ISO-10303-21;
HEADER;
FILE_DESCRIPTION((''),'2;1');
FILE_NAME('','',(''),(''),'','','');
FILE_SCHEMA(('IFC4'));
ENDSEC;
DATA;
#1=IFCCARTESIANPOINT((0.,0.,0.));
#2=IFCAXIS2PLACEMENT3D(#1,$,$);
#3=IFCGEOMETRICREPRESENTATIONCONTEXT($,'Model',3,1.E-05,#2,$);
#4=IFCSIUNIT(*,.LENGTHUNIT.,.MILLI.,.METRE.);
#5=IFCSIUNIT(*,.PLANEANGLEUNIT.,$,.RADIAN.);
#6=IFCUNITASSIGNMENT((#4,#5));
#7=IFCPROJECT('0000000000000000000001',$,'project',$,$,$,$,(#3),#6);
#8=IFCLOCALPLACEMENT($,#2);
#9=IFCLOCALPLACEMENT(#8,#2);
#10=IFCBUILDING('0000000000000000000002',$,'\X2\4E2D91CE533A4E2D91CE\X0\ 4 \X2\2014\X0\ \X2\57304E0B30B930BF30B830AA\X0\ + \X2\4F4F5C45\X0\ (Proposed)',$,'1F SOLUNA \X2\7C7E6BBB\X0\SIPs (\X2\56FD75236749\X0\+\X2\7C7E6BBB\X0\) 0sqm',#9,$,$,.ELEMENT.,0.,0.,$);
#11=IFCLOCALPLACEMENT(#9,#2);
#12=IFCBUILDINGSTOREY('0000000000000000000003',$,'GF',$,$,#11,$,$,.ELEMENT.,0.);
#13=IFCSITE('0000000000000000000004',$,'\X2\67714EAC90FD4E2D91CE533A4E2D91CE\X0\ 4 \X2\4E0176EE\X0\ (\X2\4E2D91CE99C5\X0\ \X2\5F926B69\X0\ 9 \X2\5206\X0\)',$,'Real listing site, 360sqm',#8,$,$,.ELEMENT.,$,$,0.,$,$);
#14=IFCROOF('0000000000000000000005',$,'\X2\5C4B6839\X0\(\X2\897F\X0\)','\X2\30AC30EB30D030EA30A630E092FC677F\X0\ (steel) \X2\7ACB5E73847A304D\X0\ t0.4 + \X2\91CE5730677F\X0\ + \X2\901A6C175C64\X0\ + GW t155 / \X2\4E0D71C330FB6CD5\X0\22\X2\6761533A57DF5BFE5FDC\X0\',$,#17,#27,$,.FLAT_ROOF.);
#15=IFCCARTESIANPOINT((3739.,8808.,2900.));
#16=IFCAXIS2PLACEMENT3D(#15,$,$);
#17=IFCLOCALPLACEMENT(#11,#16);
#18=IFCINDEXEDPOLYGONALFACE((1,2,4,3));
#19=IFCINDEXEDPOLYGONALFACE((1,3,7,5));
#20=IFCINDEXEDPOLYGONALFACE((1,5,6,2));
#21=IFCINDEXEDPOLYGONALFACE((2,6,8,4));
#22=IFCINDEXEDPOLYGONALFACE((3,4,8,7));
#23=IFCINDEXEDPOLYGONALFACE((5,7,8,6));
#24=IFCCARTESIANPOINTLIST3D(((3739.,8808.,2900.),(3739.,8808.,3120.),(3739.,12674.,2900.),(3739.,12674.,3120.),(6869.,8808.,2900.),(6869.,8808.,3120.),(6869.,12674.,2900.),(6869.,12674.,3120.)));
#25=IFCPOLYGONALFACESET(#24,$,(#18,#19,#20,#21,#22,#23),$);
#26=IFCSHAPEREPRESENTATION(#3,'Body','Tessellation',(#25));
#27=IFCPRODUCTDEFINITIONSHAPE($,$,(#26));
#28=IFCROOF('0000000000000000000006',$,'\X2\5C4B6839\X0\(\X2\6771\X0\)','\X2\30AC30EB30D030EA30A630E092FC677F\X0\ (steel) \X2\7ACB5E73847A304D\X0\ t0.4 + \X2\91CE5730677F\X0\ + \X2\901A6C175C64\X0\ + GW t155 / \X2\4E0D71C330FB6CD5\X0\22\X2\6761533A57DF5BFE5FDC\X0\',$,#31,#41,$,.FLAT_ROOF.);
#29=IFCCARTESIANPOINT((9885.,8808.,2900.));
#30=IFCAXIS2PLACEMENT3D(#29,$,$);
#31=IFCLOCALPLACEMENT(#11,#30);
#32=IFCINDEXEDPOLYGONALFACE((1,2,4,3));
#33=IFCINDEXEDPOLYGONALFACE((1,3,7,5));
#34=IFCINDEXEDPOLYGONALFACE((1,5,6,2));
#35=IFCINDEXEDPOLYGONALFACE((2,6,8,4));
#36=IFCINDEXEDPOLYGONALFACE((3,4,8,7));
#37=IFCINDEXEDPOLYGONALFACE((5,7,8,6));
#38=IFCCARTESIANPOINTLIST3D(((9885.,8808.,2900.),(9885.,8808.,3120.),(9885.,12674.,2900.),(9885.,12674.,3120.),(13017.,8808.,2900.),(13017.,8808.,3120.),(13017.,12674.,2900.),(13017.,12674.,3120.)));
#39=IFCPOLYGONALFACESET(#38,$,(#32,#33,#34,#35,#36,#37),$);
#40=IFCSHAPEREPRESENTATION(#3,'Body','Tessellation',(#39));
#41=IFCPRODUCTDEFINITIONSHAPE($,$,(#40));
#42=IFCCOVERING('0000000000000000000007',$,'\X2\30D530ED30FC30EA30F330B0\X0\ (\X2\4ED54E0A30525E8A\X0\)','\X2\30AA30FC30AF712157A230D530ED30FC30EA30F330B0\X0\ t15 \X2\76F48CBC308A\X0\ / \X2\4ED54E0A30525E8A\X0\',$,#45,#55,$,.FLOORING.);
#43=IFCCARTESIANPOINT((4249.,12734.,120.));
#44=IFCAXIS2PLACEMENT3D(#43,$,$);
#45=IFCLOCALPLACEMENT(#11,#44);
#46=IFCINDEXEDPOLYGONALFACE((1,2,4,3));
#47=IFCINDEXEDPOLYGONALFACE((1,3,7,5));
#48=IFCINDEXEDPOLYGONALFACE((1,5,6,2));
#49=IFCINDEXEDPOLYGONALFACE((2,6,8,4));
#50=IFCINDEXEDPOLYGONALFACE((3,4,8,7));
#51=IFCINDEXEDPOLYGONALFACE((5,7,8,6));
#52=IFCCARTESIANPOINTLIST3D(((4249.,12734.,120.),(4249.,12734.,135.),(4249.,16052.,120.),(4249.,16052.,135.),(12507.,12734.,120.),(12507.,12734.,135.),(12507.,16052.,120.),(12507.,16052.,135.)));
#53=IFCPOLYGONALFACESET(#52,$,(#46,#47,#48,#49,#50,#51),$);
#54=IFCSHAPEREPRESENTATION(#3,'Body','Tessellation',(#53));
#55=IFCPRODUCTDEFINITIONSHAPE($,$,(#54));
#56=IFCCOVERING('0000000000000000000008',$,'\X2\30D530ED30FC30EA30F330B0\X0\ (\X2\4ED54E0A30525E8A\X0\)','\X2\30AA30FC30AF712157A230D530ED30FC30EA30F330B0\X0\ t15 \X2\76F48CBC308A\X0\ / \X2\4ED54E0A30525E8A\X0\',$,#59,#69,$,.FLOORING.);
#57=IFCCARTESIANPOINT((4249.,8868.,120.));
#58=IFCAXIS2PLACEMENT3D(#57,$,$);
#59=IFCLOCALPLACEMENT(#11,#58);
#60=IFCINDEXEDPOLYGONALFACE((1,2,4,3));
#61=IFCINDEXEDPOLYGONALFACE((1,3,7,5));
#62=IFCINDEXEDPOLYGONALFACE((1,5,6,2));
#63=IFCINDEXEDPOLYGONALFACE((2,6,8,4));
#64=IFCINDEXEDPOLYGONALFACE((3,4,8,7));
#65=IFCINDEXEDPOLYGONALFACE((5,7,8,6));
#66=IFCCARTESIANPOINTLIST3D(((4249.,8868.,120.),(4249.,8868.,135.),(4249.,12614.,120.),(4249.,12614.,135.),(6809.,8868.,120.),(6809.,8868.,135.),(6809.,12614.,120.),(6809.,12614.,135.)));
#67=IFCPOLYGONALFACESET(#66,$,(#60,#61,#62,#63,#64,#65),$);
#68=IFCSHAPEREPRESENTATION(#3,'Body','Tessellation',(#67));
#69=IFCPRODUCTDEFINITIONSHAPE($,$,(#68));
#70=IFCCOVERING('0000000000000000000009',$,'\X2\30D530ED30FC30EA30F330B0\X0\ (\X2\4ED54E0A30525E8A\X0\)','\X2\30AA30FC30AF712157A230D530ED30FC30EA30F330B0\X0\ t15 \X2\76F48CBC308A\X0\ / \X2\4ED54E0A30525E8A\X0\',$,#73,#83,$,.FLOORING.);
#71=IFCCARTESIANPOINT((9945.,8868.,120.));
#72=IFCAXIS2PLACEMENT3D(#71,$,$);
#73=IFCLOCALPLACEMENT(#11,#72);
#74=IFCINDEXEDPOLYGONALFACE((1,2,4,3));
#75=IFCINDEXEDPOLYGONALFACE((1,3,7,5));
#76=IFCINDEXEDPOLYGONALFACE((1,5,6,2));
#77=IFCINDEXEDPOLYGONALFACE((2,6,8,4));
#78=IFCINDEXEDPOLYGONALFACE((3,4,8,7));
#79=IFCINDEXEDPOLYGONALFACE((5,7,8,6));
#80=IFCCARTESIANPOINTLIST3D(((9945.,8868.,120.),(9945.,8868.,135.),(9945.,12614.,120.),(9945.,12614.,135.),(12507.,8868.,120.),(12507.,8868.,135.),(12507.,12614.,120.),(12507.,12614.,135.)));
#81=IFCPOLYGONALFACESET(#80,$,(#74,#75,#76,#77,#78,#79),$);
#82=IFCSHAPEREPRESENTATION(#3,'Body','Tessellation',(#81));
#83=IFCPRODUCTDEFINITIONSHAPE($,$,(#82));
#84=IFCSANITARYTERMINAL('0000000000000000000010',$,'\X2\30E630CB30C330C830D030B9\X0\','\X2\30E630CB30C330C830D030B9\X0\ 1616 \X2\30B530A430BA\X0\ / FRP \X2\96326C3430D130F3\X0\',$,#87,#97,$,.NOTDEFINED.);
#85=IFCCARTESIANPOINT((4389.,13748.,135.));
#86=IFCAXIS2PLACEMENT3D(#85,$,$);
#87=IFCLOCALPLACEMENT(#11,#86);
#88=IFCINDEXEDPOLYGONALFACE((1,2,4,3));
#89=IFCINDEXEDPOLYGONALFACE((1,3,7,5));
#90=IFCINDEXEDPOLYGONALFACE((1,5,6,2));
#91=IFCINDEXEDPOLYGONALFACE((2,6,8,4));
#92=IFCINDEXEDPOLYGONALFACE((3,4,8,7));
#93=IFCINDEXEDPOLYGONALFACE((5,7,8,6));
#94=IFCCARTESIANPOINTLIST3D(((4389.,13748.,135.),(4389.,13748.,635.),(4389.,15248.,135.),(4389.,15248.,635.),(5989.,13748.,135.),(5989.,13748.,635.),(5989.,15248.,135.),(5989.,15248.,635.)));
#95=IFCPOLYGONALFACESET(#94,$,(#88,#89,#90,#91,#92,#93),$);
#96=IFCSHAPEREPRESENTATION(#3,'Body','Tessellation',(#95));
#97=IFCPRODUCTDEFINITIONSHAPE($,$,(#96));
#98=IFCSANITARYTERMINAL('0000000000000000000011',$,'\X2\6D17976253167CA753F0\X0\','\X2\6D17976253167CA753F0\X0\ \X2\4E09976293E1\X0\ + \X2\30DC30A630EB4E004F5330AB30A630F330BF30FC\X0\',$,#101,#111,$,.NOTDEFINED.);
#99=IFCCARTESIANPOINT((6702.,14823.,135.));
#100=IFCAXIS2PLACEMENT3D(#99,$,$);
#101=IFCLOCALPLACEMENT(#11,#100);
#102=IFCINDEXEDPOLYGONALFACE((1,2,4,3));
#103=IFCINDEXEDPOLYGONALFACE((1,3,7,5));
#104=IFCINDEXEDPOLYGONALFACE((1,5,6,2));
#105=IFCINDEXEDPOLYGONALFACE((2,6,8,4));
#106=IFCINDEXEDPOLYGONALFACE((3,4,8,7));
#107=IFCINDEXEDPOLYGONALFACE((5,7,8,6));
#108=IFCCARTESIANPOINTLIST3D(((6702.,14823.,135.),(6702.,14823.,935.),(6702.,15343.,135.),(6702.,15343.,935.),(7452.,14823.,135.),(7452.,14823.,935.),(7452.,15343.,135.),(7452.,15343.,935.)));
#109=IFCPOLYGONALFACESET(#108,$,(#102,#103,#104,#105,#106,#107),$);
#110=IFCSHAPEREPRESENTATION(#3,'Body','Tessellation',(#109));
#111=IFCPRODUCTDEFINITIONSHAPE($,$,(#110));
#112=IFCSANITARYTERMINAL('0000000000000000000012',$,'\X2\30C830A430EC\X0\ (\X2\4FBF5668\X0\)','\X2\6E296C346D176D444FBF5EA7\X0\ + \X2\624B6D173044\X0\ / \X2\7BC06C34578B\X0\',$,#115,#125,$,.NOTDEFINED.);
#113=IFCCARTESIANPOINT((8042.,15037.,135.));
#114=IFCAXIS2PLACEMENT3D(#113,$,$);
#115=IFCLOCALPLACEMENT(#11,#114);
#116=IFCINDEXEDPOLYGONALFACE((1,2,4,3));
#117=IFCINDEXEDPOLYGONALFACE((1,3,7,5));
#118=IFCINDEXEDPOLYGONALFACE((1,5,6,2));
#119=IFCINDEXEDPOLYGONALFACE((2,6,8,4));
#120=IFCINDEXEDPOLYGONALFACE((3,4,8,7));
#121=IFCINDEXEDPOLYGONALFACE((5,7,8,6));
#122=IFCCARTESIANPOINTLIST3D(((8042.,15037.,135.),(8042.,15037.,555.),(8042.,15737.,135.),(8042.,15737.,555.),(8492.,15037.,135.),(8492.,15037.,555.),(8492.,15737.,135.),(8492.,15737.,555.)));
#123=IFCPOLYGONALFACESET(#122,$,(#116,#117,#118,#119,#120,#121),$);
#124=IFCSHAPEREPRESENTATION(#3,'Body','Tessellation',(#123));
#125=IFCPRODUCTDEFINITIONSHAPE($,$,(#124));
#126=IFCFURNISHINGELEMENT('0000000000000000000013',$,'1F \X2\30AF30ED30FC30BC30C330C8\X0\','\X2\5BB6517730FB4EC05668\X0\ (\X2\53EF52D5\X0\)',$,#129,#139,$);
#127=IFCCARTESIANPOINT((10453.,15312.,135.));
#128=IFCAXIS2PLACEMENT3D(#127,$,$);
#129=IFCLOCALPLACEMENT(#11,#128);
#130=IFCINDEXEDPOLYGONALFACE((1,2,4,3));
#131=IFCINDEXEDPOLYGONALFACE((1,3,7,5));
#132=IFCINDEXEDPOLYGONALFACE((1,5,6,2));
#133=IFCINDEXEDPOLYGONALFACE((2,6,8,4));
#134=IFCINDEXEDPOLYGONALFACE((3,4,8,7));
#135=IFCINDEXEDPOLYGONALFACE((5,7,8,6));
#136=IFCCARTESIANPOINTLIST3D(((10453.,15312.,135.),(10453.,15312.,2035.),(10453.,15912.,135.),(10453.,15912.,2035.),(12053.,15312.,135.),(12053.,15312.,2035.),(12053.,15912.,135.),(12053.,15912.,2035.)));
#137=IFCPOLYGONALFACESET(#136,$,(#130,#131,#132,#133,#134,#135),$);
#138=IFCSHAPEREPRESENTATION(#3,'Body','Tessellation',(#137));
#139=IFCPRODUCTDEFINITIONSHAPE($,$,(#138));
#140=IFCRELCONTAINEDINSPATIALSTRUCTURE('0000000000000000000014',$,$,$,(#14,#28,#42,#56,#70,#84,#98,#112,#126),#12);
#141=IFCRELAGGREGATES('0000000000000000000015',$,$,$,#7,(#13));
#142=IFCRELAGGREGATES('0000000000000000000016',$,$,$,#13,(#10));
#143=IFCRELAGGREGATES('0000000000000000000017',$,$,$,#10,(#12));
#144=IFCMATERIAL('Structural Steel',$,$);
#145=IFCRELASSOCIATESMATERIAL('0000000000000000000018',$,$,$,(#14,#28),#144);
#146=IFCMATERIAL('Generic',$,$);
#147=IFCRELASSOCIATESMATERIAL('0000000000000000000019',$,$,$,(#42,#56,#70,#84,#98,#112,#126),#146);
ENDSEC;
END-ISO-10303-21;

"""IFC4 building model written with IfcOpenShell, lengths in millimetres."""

from ifc_helpers import new_model, si_unit, frame, frame_2d, origin, place, context, project, spatial, rectangle, extrude, material, element, save


model = new_model("IFC4")

# Units and contexts
model_context = context("Model", 3, precision=1e-05, world=origin())
ifc_project = project(units=[si_unit("LENGTHUNIT", "METRE", prefix="MILLI"), si_unit("PLANEANGLEUNIT", "RADIAN")], contexts=[model_context])

# Site, building, storey
site_placement = place(None, origin())
site = spatial("IfcSite", under=ifc_project, at=site_placement, Name="東京都中野区中野 4 丁目 (中野駅 徒歩 9 分)", ObjectType="Real listing site, 360sqm", CompositionType="ELEMENT", RefElevation=0.0)
building_placement = place(site_placement, origin())
building = spatial("IfcBuilding", under=site, at=building_placement, Name="中野区中野 4 — 地下スタジオ + 住居 (Proposed)", ObjectType="1F SOLUNA 籾殻SIPs (国産杉+籾殻) 0sqm", CompositionType="ELEMENT", ElevationOfRefHeight=0.0, ElevationOfTerrain=0.0)
storey_placement = place(building_placement, origin())
storey = spatial("IfcBuildingStorey", under=building, at=storey_placement, Name="GF", CompositionType="ELEMENT", Elevation=0.0)

# Roofs
ifc_material_1 = material(Name="Structural Steel")
roof_1_placement = place(storey_placement, frame((3739.0, 8808.0, 2900.0)))
element("IfcRoof", 1, at=roof_1_placement, inside=storey, material=ifc_material_1, Name="屋根(西)", Description="ガルバリウム鋼板 (steel) 立平葺き t0.4 + 野地板 + 通気層 + GW t155 / 不燃・法22条区域対応", PredefinedType="FLAT_ROOF", context=model_context, shape_type="SweptSolid", body=[
    extrude(rectangle(XDim=3130.0, YDim=3866.0, at=frame_2d((1565.0, 1933.0))), frame((3739.0, 8808.0, 2900.0)), (0.0, 0.0, 1.0), 220.0),
])
roof_2_placement = place(storey_placement, frame((9885.0, 8808.0, 2900.0)))
element("IfcRoof", 2, at=roof_2_placement, inside=storey, material=ifc_material_1, Name="屋根(東)", Description="ガルバリウム鋼板 (steel) 立平葺き t0.4 + 野地板 + 通気層 + GW t155 / 不燃・法22条区域対応", PredefinedType="FLAT_ROOF", context=model_context, shape_type="SweptSolid", body=[
    extrude(rectangle(XDim=3132.0, YDim=3866.0, at=frame_2d((1566.0, 1933.0))), frame((9885.0, 8808.0, 2900.0)), (0.0, 0.0, 1.0), 220.0),
])

# Coverings
ifc_material_2 = material(Name="Generic")
covering_1_placement = place(storey_placement, frame((4249.0, 12734.0, 120.0)))
element("IfcCovering", 3, at=covering_1_placement, inside=storey, material=ifc_material_2, Name="フローリング (仕上げ床)", Description="オーク無垢フローリング t15 直貼り / 仕上げ床", PredefinedType="FLOORING", context=model_context, shape_type="SweptSolid", body=[
    extrude(rectangle(XDim=8258.0, YDim=3318.0, at=frame_2d((4129.0, 1659.0))), frame((4249.0, 12734.0, 120.0)), (0.0, 0.0, 1.0), 15.0),
])
covering_2_placement = place(storey_placement, frame((4249.0, 8868.0, 120.0)))
element("IfcCovering", 4, at=covering_2_placement, inside=storey, material=ifc_material_2, Name="フローリング (仕上げ床)", Description="オーク無垢フローリング t15 直貼り / 仕上げ床", PredefinedType="FLOORING", context=model_context, shape_type="SweptSolid", body=[
    extrude(rectangle(XDim=2560.0, YDim=3746.0, at=frame_2d((1280.0, 1873.0))), frame((4249.0, 8868.0, 120.0)), (0.0, 0.0, 1.0), 15.0),
])
covering_3_placement = place(storey_placement, frame((9945.0, 8868.0, 120.0)))
element("IfcCovering", 5, at=covering_3_placement, inside=storey, material=ifc_material_2, Name="フローリング (仕上げ床)", Description="オーク無垢フローリング t15 直貼り / 仕上げ床", PredefinedType="FLOORING", context=model_context, shape_type="SweptSolid", body=[
    extrude(rectangle(XDim=2562.0, YDim=3746.0, at=frame_2d((1281.0, 1873.0))), frame((9945.0, 8868.0, 120.0)), (0.0, 0.0, 1.0), 15.0),
])

# Sanitary terminals
sanitary_terminal_1_placement = place(storey_placement, frame((4389.0, 13748.0, 135.0)))
element("IfcSanitaryTerminal", 6, at=sanitary_terminal_1_placement, inside=storey, material=ifc_material_2, Name="ユニットバス", Description="ユニットバス 1616 サイズ / FRP 防水パン", PredefinedType="NOTDEFINED", context=model_context, shape_type="SweptSolid", body=[
    extrude(rectangle(XDim=1600.0, YDim=1500.0, at=frame_2d((800.0, 750.0))), frame((4389.0, 13748.0, 135.0)), (0.0, 0.0, 1.0), 500.0),
])
sanitary_terminal_2_placement = place(storey_placement, frame((6702.0, 14823.0, 135.0)))
element("IfcSanitaryTerminal", 7, at=sanitary_terminal_2_placement, inside=storey, material=ifc_material_2, Name="洗面化粧台", Description="洗面化粧台 三面鏡 + ボウル一体カウンター", PredefinedType="NOTDEFINED", context=model_context, shape_type="SweptSolid", body=[
    extrude(rectangle(XDim=750.0, YDim=520.0, at=frame_2d((375.0, 260.0))), frame((6702.0, 14823.0, 135.0)), (0.0, 0.0, 1.0), 800.0),
])
sanitary_terminal_3_placement = place(storey_placement, frame((8042.0, 15037.0, 135.0)))
element("IfcSanitaryTerminal", 8, at=sanitary_terminal_3_placement, inside=storey, material=ifc_material_2, Name="トイレ (便器)", Description="温水洗浄便座 + 手洗い / 節水型", PredefinedType="NOTDEFINED", context=model_context, shape_type="SweptSolid", body=[
    extrude(rectangle(XDim=450.0, YDim=700.0, at=frame_2d((225.0, 350.0))), frame((8042.0, 15037.0, 135.0)), (0.0, 0.0, 1.0), 420.0),
])

# Furnishing element
furnishing_placement = place(storey_placement, frame((10453.0, 15312.0, 135.0)))
element("IfcFurnishingElement", 9, at=furnishing_placement, inside=storey, material=ifc_material_2, Name="1F クローゼット", Description="家具・什器 (可動)", context=model_context, shape_type="SweptSolid", body=[
    extrude(rectangle(XDim=1600.0, YDim=600.0, at=frame_2d((800.0, 300.0))), frame((10453.0, 15312.0, 135.0)), (0.0, 0.0, 1.0), 1900.0),
])

save(model, "model.ifc")
